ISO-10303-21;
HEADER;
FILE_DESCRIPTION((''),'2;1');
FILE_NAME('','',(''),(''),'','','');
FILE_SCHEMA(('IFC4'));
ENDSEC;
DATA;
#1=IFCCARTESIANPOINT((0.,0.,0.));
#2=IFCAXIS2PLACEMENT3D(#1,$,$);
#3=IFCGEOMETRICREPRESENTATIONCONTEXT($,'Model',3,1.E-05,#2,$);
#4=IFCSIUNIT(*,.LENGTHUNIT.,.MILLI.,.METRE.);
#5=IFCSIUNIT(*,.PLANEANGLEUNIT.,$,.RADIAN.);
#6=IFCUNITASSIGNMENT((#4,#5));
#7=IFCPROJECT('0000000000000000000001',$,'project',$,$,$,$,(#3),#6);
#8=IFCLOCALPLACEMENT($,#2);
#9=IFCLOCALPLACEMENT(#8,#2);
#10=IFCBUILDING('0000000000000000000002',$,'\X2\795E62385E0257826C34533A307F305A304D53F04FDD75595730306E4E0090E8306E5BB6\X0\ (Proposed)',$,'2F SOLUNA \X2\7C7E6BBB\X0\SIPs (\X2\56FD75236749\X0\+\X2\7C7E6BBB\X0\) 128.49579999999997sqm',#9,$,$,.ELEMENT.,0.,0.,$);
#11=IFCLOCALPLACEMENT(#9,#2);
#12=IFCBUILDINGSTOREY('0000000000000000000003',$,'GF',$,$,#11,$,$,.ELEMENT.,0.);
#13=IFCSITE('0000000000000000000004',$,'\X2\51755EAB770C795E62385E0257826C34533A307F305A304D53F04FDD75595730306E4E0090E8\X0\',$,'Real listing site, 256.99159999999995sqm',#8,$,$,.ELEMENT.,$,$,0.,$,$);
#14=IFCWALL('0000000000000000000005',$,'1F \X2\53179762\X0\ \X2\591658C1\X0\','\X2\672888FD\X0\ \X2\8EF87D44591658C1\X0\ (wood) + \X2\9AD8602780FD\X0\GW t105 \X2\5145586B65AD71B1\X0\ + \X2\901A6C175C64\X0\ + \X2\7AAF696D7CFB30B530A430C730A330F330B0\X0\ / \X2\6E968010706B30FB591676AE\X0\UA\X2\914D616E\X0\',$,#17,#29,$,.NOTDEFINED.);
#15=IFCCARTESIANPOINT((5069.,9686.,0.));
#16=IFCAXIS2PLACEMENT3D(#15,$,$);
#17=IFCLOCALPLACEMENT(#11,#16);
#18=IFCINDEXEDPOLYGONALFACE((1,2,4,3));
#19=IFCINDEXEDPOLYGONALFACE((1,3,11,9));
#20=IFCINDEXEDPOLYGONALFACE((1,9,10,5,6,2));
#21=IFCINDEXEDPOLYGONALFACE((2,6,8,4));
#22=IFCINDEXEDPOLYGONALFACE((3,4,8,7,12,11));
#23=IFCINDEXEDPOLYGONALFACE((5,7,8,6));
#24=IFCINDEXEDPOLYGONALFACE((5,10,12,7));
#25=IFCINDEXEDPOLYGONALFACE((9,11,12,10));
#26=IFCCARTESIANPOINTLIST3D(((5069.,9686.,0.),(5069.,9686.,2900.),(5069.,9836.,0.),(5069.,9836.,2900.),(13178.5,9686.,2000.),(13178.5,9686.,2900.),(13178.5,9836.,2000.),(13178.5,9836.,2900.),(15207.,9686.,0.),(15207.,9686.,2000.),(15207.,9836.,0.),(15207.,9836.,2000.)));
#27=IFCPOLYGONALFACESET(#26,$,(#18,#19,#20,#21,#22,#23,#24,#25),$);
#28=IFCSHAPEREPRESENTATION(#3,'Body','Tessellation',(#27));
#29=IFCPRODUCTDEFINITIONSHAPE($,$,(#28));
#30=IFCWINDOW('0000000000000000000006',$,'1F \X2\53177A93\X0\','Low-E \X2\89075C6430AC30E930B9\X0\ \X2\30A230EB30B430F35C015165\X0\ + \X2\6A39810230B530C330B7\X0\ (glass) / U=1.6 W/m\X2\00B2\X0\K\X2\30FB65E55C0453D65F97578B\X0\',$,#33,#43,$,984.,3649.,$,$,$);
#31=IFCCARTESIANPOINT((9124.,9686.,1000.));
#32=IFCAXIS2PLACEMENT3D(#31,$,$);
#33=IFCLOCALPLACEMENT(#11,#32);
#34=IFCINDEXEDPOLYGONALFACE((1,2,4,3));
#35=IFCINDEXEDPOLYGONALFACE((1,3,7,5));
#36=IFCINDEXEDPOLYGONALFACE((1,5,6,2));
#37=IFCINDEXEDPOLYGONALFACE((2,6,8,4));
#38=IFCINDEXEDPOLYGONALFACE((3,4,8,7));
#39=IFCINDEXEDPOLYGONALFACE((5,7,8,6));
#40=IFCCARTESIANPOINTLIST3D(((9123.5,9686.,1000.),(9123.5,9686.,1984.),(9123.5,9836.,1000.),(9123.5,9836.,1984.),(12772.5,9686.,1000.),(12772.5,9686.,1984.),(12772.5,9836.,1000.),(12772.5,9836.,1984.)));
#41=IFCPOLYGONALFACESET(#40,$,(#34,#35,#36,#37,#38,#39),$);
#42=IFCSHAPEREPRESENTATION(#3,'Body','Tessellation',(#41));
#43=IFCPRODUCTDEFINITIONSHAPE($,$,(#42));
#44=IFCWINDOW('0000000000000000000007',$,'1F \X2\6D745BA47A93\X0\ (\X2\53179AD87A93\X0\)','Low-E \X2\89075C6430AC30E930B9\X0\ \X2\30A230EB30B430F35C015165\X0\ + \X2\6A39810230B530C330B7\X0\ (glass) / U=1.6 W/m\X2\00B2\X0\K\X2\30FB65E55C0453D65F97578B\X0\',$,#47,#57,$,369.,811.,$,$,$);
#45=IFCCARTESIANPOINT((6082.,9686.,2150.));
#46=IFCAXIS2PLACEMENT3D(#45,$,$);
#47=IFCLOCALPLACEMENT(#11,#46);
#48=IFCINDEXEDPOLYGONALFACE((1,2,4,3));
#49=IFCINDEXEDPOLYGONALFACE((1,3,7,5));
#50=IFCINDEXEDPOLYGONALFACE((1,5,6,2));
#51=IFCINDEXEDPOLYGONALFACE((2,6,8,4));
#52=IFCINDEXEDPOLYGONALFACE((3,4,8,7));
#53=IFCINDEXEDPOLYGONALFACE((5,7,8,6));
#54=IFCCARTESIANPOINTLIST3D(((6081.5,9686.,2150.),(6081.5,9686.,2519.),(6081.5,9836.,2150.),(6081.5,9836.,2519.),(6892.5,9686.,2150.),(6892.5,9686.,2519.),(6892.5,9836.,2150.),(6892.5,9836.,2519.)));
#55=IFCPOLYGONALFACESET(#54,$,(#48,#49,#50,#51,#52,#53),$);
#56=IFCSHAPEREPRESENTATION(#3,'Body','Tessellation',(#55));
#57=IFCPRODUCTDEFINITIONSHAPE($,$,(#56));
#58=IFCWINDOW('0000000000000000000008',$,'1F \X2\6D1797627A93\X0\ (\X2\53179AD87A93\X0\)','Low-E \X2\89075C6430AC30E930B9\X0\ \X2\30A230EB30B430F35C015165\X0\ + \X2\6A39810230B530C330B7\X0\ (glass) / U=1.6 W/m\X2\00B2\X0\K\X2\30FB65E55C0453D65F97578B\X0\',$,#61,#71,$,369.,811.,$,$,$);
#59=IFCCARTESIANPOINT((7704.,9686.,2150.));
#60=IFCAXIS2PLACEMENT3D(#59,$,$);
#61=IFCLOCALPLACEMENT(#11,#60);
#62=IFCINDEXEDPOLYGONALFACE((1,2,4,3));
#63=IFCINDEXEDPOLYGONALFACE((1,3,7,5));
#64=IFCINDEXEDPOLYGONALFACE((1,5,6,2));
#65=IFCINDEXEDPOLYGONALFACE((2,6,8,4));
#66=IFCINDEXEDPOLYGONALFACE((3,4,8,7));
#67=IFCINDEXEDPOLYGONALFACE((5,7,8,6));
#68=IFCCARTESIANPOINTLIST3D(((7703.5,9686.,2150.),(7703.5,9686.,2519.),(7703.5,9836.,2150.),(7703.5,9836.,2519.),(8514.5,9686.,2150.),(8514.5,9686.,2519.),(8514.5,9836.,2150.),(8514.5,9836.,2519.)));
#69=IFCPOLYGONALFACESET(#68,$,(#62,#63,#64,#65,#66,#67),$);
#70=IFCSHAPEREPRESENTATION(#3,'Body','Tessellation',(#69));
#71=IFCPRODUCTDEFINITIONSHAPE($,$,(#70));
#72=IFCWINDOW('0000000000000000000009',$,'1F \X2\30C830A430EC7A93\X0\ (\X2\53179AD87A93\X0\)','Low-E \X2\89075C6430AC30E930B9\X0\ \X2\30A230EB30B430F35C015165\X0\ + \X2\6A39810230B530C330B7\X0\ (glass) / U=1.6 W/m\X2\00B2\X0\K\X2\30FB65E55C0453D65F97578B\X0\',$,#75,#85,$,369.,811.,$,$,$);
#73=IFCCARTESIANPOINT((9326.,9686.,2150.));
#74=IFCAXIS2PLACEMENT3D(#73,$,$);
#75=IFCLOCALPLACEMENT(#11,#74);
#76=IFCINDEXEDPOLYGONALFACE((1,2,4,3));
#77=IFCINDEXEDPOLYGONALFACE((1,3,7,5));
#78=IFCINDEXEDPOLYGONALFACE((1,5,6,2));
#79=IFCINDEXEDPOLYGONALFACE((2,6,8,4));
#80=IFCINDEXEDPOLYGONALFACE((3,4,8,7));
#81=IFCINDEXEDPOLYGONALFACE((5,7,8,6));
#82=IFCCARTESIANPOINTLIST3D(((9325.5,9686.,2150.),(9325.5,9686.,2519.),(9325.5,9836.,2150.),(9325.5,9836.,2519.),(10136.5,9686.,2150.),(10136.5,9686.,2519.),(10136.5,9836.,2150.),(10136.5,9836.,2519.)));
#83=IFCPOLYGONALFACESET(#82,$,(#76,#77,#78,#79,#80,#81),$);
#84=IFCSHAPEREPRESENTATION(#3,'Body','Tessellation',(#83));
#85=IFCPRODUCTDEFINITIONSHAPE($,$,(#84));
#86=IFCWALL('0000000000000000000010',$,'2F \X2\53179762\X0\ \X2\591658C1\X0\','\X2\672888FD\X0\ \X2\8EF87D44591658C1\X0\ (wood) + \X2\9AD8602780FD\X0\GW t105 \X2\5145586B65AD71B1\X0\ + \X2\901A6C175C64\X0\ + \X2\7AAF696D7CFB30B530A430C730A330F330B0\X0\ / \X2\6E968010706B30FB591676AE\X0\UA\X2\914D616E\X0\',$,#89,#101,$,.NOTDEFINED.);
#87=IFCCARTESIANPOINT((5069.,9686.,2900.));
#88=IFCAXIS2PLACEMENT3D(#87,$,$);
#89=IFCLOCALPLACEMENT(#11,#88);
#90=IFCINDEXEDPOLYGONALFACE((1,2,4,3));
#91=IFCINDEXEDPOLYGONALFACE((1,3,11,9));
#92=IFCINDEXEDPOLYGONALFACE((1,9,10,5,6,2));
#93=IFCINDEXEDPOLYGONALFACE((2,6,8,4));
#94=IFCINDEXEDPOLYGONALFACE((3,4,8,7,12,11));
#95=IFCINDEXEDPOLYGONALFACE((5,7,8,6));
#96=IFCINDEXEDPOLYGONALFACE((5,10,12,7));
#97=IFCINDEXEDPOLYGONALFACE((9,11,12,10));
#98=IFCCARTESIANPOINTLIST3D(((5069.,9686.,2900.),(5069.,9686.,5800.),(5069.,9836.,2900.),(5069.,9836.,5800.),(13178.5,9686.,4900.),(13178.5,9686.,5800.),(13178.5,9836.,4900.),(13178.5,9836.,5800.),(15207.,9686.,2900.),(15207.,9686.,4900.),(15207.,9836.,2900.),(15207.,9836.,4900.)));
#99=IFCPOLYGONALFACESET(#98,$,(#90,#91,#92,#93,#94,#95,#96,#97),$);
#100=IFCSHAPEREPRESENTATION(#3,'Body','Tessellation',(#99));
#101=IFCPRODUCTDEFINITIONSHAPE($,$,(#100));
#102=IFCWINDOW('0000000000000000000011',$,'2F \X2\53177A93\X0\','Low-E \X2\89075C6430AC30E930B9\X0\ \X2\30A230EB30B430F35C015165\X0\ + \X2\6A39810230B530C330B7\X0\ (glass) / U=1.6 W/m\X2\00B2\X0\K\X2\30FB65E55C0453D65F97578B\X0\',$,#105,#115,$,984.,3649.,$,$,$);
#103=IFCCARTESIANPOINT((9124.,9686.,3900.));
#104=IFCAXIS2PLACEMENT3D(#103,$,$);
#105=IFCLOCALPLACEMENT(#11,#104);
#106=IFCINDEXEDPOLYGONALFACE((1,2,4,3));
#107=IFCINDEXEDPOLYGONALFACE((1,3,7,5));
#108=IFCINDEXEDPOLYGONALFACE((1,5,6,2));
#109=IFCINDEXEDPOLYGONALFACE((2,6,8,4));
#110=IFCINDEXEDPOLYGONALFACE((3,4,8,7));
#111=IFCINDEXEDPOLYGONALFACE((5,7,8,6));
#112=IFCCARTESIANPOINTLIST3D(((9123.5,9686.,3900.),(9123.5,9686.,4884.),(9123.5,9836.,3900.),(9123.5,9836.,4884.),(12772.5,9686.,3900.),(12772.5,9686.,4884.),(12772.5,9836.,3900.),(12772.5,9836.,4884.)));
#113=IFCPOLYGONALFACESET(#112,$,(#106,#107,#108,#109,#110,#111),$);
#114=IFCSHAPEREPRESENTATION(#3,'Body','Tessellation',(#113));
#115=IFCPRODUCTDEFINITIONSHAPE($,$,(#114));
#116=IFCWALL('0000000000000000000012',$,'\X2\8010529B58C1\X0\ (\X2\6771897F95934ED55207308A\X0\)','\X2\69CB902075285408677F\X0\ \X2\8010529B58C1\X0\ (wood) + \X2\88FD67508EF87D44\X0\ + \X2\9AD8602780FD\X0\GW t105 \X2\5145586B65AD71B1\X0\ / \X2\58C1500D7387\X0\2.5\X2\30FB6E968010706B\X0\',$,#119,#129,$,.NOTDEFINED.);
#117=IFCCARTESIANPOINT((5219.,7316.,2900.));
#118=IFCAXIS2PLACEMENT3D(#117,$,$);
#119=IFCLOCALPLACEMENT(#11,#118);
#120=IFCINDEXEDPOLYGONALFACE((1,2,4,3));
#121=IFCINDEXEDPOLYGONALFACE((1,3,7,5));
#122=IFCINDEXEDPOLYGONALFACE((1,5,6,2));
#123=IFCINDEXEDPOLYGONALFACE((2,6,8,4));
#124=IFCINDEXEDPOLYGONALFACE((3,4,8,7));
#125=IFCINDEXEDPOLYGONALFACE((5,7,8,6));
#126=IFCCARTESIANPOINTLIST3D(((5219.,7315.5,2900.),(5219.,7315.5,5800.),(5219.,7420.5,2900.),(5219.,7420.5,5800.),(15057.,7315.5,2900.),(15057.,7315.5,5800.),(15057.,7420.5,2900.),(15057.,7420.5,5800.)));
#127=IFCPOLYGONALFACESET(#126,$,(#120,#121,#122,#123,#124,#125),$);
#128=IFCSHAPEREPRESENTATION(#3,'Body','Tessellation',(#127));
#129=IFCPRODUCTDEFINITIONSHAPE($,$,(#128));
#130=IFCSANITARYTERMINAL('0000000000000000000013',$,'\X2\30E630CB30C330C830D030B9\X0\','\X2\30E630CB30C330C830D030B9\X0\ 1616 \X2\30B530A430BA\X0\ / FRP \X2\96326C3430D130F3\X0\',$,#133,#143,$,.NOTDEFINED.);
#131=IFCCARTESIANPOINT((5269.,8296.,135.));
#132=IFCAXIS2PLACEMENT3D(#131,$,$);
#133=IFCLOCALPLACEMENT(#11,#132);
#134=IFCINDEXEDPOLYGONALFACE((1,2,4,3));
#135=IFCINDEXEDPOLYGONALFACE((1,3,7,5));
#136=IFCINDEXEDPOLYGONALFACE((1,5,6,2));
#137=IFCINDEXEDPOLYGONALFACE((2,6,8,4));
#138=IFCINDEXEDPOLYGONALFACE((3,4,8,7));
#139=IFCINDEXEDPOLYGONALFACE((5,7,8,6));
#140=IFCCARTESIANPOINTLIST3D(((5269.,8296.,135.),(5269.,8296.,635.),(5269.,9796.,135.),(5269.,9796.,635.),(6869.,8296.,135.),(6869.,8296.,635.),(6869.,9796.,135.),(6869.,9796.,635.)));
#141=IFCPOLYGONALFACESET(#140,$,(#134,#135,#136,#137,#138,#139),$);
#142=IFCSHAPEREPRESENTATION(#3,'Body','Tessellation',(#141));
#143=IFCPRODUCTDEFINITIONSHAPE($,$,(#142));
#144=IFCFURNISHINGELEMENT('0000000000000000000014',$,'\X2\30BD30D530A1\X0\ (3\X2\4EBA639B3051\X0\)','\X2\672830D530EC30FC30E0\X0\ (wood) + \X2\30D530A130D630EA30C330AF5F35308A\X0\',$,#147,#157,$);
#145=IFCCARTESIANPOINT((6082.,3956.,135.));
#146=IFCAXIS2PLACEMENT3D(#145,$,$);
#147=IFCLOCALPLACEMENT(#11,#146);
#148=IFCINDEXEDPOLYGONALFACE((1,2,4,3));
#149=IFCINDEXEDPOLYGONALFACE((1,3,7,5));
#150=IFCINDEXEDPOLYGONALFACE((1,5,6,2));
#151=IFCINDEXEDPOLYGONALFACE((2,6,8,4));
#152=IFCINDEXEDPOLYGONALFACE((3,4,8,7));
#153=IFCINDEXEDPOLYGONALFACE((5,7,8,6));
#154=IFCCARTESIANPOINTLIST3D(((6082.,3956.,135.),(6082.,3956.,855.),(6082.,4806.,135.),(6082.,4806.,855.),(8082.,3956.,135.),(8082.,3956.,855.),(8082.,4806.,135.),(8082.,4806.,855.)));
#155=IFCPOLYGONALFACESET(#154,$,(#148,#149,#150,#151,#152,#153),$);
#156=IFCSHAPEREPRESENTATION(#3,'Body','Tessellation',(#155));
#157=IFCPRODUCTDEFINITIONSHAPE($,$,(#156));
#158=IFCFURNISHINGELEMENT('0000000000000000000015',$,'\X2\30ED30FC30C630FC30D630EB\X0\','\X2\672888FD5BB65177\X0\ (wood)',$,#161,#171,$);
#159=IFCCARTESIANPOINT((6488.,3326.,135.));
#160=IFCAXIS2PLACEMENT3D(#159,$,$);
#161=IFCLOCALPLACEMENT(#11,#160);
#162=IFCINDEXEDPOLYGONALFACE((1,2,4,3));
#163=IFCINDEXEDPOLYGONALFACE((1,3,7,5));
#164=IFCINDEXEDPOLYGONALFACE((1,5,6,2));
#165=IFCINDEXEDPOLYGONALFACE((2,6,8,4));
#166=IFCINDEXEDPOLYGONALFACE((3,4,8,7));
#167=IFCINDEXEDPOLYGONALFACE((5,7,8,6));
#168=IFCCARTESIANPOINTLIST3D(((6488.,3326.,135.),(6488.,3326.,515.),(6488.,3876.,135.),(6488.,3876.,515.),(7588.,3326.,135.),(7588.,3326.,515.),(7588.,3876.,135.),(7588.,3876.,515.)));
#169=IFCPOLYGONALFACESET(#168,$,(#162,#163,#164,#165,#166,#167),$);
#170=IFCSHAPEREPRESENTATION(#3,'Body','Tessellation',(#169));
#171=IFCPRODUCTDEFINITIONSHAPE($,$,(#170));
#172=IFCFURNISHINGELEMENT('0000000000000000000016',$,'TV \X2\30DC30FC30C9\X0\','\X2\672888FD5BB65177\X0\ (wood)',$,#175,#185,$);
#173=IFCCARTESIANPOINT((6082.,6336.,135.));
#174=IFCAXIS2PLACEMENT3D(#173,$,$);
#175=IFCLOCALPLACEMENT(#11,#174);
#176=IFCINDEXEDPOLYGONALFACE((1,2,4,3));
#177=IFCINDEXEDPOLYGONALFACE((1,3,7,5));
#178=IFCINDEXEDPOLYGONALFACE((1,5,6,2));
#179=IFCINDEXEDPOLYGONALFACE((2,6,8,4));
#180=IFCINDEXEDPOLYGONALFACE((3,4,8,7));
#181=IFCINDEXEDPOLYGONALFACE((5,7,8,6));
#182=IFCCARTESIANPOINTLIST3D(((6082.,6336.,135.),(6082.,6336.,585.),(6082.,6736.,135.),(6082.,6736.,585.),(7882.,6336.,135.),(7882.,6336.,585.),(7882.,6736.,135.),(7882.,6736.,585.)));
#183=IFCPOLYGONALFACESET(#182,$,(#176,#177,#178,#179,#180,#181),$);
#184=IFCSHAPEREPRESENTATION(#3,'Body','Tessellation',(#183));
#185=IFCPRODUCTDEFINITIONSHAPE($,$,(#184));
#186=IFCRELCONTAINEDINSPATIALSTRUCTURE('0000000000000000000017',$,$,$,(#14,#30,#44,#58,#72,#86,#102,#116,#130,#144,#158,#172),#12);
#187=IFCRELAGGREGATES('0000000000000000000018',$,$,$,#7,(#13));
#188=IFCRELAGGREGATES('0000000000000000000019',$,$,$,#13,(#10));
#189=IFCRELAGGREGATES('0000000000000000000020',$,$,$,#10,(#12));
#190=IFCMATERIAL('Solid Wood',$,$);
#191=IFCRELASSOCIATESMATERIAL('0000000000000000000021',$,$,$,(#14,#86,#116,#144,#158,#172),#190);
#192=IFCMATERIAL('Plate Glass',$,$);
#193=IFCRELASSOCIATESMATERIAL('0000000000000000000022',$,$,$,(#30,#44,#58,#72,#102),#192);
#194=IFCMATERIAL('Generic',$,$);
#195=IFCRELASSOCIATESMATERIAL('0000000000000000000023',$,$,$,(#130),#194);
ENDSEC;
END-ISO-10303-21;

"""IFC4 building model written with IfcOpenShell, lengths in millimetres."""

from ifc_helpers import new_model, si_unit, frame, frame_2d, origin, place, context, project, spatial, rectangle, extrude, material, element, fill, save


model = new_model("IFC4")

# Units and contexts
model_context = context("Model", 3, precision=1e-05, world=origin())
ifc_project = project(units=[si_unit("LENGTHUNIT", "METRE", prefix="MILLI"), si_unit("PLANEANGLEUNIT", "RADIAN")], contexts=[model_context])

# Site, building, storey
site_placement = place(None, origin())
site = spatial("IfcSite", under=ifc_project, at=site_placement, Name="兵庫県神戸市垂水区みずき台保留地の一部", ObjectType="Real listing site, 256.99159999999995sqm", CompositionType="ELEMENT", RefElevation=0.0)
building_placement = place(site_placement, origin())
building = spatial("IfcBuilding", under=site, at=building_placement, Name="神戸市垂水区みずき台保留地の一部の家 (Proposed)", ObjectType="2F SOLUNA 籾殻SIPs (国産杉+籾殻) 128.49579999999997sqm", CompositionType="ELEMENT", ElevationOfRefHeight=0.0, ElevationOfTerrain=0.0)
storey_placement = place(building_placement, origin())
storey = spatial("IfcBuildingStorey", under=building, at=storey_placement, Name="GF", CompositionType="ELEMENT", Elevation=0.0)

# Wall, openings, windows
ifc_material_1 = material(Name="Solid Wood")
wall_1_placement = place(storey_placement, frame((5069.0, 9686.0, 0.0)))
wall_1 = element("IfcWall", 1, at=wall_1_placement, inside=storey, material=ifc_material_1, Name="1F 北面 外壁", Description="木製 軸組外壁 (wood) + 高性能GW t105 充填断熱 + 通気層 + 窯業系サイディング / 準耐火・外皮UA配慮", PredefinedType="NOTDEFINED", context=model_context, shape_type="SweptSolid", body=[
    extrude(rectangle(XDim=10138.0, YDim=150.0, at=frame_2d((5069.0, 75.0))), frame((5069.0, 9686.0, 0.0)), (0.0, 0.0, 1.0), 2900.0),
])
opening_1_placement = place(storey_placement, frame((9124.0, 9686.0, 1000.0)))
opening_1 = element("IfcOpeningElement", 2, at=opening_1_placement, cuts=wall_1, PredefinedType="NOTDEFINED", context=model_context, shape_type="SweptSolid", body=[
    extrude(rectangle(XDim=3649.0, YDim=150.0, at=frame_2d((1824.0, 75.0))), frame((9124.0, 9686.0, 1000.0)), (0.0, 0.0, 1.0), 984.0),
])
opening_2_placement = place(storey_placement, frame((6082.0, 9686.0, 2150.0)))
opening_2 = element("IfcOpeningElement", 3, at=opening_2_placement, cuts=wall_1, PredefinedType="NOTDEFINED", context=model_context, shape_type="SweptSolid", body=[
    extrude(rectangle(XDim=811.0, YDim=150.0, at=frame_2d((405.0, 75.0))), frame((6082.0, 9686.0, 2150.0)), (0.0, 0.0, 1.0), 369.0),
])
opening_3_placement = place(storey_placement, frame((7704.0, 9686.0, 2150.0)))
opening_3 = element("IfcOpeningElement", 4, at=opening_3_placement, cuts=wall_1, PredefinedType="NOTDEFINED", context=model_context, shape_type="SweptSolid", body=[
    extrude(rectangle(XDim=811.0, YDim=150.0, at=frame_2d((405.0, 75.0))), frame((7704.0, 9686.0, 2150.0)), (0.0, 0.0, 1.0), 369.0),
])
opening_4_placement = place(storey_placement, frame((9326.0, 9686.0, 2150.0)))
opening_4 = element("IfcOpeningElement", 5, at=opening_4_placement, cuts=wall_1, PredefinedType="NOTDEFINED", context=model_context, shape_type="SweptSolid", body=[
    extrude(rectangle(XDim=811.0, YDim=150.0, at=frame_2d((405.0, 75.0))), frame((9326.0, 9686.0, 2150.0)), (0.0, 0.0, 1.0), 369.0),
])
ifc_material_2 = material(Name="Plate Glass")
window_1_placement = place(storey_placement, frame((9124.0, 9686.0, 1000.0)))
window_1 = element("IfcWindow", 6, at=window_1_placement, inside=storey, material=ifc_material_2, Name="1F 北窓", Description="Low-E 複層ガラス アルゴン封入 + 樹脂サッシ (glass) / U=1.6 W/m²K・日射取得型", OverallHeight=984.0, OverallWidth=3649.0, context=model_context, shape_type="SweptSolid", body=[
    extrude(rectangle(XDim=3649.0, YDim=150.0, at=frame_2d((1824.0, 75.0))), frame((9124.0, 9686.0, 1000.0)), (0.0, 0.0, 1.0), 984.0),
])
fill(opening_1, window_1)
window_2_placement = place(storey_placement, frame((6082.0, 9686.0, 2150.0)))
window_2 = element("IfcWindow", 7, at=window_2_placement, inside=storey, material=ifc_material_2, Name="1F 浴室窓 (北高窓)", Description="Low-E 複層ガラス アルゴン封入 + 樹脂サッシ (glass) / U=1.6 W/m²K・日射取得型", OverallHeight=369.0, OverallWidth=811.0, context=model_context, shape_type="SweptSolid", body=[
    extrude(rectangle(XDim=811.0, YDim=150.0, at=frame_2d((405.0, 75.0))), frame((6082.0, 9686.0, 2150.0)), (0.0, 0.0, 1.0), 369.0),
])
fill(opening_2, window_2)
window_3_placement = place(storey_placement, frame((7704.0, 9686.0, 2150.0)))
window_3 = element("IfcWindow", 8, at=window_3_placement, inside=storey, material=ifc_material_2, Name="1F 洗面窓 (北高窓)", Description="Low-E 複層ガラス アルゴン封入 + 樹脂サッシ (glass) / U=1.6 W/m²K・日射取得型", OverallHeight=369.0, OverallWidth=811.0, context=model_context, shape_type="SweptSolid", body=[
    extrude(rectangle(XDim=811.0, YDim=150.0, at=frame_2d((405.0, 75.0))), frame((7704.0, 9686.0, 2150.0)), (0.0, 0.0, 1.0), 369.0),
])
fill(opening_3, window_3)
window_4_placement = place(storey_placement, frame((9326.0, 9686.0, 2150.0)))
window_4 = element("IfcWindow", 9, at=window_4_placement, inside=storey, material=ifc_material_2, Name="1F トイレ窓 (北高窓)", Description="Low-E 複層ガラス アルゴン封入 + 樹脂サッシ (glass) / U=1.6 W/m²K・日射取得型", OverallHeight=369.0, OverallWidth=811.0, context=model_context, shape_type="SweptSolid", body=[
    extrude(rectangle(XDim=811.0, YDim=150.0, at=frame_2d((405.0, 75.0))), frame((9326.0, 9686.0, 2150.0)), (0.0, 0.0, 1.0), 369.0),
])
fill(opening_4, window_4)

# Wall, opening, window
wall_2_placement = place(storey_placement, frame((5069.0, 9686.0, 2900.0)))
wall_2 = element("IfcWall", 10, at=wall_2_placement, inside=storey, material=ifc_material_1, Name="2F 北面 外壁", Description="木製 軸組外壁 (wood) + 高性能GW t105 充填断熱 + 通気層 + 窯業系サイディング / 準耐火・外皮UA配慮", PredefinedType="NOTDEFINED", context=model_context, shape_type="SweptSolid", body=[
    extrude(rectangle(XDim=10138.0, YDim=150.0, at=frame_2d((5069.0, 75.0))), frame((5069.0, 9686.0, 2900.0)), (0.0, 0.0, 1.0), 2900.0),
])
opening_5_placement = place(storey_placement, frame((9124.0, 9686.0, 3900.0)))
opening_5 = element("IfcOpeningElement", 11, at=opening_5_placement, cuts=wall_2, PredefinedType="NOTDEFINED", context=model_context, shape_type="SweptSolid", body=[
    extrude(rectangle(XDim=3649.0, YDim=150.0, at=frame_2d((1824.0, 75.0))), frame((9124.0, 9686.0, 3900.0)), (0.0, 0.0, 1.0), 984.0),
])
window_5_placement = place(storey_placement, frame((9124.0, 9686.0, 3900.0)))
window_5 = element("IfcWindow", 12, at=window_5_placement, inside=storey, material=ifc_material_2, Name="2F 北窓", Description="Low-E 複層ガラス アルゴン封入 + 樹脂サッシ (glass) / U=1.6 W/m²K・日射取得型", OverallHeight=984.0, OverallWidth=3649.0, context=model_context, shape_type="SweptSolid", body=[
    extrude(rectangle(XDim=3649.0, YDim=150.0, at=frame_2d((1824.0, 75.0))), frame((9124.0, 9686.0, 3900.0)), (0.0, 0.0, 1.0), 984.0),
])
fill(opening_5, window_5)

# Wall
wall_3_placement = place(storey_placement, frame((5219.0, 7316.0, 2900.0)))
element("IfcWall", 13, at=wall_3_placement, inside=storey, material=ifc_material_1, Name="耐力壁 (東西間仕切り)", Description="構造用合板 耐力壁 (wood) + 製材軸組 + 高性能GW t105 充填断熱 / 壁倍率2.5・準耐火", PredefinedType="NOTDEFINED", context=model_context, shape_type="SweptSolid", body=[
    extrude(rectangle(XDim=9838.0, YDim=105.0, at=frame_2d((4919.0, 52.0))), frame((5219.0, 7316.0, 2900.0)), (0.0, 0.0, 1.0), 2900.0),
])

# Sanitary terminal
ifc_material_3 = material(Name="Generic")
sanitary_terminal_placement = place(storey_placement, frame((5269.0, 8296.0, 135.0)))
element("IfcSanitaryTerminal", 14, at=sanitary_terminal_placement, inside=storey, material=ifc_material_3, Name="ユニットバス", Description="ユニットバス 1616 サイズ / FRP 防水パン", PredefinedType="NOTDEFINED", context=model_context, shape_type="SweptSolid", body=[
    extrude(rectangle(XDim=1600.0, YDim=1500.0, at=frame_2d((800.0, 750.0))), frame((5269.0, 8296.0, 135.0)), (0.0, 0.0, 1.0), 500.0),
])

# Furnishing elements
furnishing_1_placement = place(storey_placement, frame((6082.0, 3956.0, 135.0)))
element("IfcFurnishingElement", 15, at=furnishing_1_placement, inside=storey, material=ifc_material_1, Name="ソファ (3人掛け)", Description="木フレーム (wood) + ファブリック張り", context=model_context, shape_type="SweptSolid", body=[
    extrude(rectangle(XDim=2000.0, YDim=850.0, at=frame_2d((1000.0, 425.0))), frame((6082.0, 3956.0, 135.0)), (0.0, 0.0, 1.0), 720.0),
])
furnishing_2_placement = place(storey_placement, frame((6488.0, 3326.0, 135.0)))
element("IfcFurnishingElement", 16, at=furnishing_2_placement, inside=storey, material=ifc_material_1, Name="ローテーブル", Description="木製家具 (wood)", context=model_context, shape_type="SweptSolid", body=[
    extrude(rectangle(XDim=1100.0, YDim=550.0, at=frame_2d((550.0, 275.0))), frame((6488.0, 3326.0, 135.0)), (0.0, 0.0, 1.0), 380.0),
])
furnishing_3_placement = place(storey_placement, frame((6082.0, 6336.0, 135.0)))
element("IfcFurnishingElement", 17, at=furnishing_3_placement, inside=storey, material=ifc_material_1, Name="TV ボード", Description="木製家具 (wood)", context=model_context, shape_type="SweptSolid", body=[
    extrude(rectangle(XDim=1800.0, YDim=400.0, at=frame_2d((900.0, 200.0))), frame((6082.0, 6336.0, 135.0)), (0.0, 0.0, 1.0), 450.0),
])

save(model, "model.ifc")
